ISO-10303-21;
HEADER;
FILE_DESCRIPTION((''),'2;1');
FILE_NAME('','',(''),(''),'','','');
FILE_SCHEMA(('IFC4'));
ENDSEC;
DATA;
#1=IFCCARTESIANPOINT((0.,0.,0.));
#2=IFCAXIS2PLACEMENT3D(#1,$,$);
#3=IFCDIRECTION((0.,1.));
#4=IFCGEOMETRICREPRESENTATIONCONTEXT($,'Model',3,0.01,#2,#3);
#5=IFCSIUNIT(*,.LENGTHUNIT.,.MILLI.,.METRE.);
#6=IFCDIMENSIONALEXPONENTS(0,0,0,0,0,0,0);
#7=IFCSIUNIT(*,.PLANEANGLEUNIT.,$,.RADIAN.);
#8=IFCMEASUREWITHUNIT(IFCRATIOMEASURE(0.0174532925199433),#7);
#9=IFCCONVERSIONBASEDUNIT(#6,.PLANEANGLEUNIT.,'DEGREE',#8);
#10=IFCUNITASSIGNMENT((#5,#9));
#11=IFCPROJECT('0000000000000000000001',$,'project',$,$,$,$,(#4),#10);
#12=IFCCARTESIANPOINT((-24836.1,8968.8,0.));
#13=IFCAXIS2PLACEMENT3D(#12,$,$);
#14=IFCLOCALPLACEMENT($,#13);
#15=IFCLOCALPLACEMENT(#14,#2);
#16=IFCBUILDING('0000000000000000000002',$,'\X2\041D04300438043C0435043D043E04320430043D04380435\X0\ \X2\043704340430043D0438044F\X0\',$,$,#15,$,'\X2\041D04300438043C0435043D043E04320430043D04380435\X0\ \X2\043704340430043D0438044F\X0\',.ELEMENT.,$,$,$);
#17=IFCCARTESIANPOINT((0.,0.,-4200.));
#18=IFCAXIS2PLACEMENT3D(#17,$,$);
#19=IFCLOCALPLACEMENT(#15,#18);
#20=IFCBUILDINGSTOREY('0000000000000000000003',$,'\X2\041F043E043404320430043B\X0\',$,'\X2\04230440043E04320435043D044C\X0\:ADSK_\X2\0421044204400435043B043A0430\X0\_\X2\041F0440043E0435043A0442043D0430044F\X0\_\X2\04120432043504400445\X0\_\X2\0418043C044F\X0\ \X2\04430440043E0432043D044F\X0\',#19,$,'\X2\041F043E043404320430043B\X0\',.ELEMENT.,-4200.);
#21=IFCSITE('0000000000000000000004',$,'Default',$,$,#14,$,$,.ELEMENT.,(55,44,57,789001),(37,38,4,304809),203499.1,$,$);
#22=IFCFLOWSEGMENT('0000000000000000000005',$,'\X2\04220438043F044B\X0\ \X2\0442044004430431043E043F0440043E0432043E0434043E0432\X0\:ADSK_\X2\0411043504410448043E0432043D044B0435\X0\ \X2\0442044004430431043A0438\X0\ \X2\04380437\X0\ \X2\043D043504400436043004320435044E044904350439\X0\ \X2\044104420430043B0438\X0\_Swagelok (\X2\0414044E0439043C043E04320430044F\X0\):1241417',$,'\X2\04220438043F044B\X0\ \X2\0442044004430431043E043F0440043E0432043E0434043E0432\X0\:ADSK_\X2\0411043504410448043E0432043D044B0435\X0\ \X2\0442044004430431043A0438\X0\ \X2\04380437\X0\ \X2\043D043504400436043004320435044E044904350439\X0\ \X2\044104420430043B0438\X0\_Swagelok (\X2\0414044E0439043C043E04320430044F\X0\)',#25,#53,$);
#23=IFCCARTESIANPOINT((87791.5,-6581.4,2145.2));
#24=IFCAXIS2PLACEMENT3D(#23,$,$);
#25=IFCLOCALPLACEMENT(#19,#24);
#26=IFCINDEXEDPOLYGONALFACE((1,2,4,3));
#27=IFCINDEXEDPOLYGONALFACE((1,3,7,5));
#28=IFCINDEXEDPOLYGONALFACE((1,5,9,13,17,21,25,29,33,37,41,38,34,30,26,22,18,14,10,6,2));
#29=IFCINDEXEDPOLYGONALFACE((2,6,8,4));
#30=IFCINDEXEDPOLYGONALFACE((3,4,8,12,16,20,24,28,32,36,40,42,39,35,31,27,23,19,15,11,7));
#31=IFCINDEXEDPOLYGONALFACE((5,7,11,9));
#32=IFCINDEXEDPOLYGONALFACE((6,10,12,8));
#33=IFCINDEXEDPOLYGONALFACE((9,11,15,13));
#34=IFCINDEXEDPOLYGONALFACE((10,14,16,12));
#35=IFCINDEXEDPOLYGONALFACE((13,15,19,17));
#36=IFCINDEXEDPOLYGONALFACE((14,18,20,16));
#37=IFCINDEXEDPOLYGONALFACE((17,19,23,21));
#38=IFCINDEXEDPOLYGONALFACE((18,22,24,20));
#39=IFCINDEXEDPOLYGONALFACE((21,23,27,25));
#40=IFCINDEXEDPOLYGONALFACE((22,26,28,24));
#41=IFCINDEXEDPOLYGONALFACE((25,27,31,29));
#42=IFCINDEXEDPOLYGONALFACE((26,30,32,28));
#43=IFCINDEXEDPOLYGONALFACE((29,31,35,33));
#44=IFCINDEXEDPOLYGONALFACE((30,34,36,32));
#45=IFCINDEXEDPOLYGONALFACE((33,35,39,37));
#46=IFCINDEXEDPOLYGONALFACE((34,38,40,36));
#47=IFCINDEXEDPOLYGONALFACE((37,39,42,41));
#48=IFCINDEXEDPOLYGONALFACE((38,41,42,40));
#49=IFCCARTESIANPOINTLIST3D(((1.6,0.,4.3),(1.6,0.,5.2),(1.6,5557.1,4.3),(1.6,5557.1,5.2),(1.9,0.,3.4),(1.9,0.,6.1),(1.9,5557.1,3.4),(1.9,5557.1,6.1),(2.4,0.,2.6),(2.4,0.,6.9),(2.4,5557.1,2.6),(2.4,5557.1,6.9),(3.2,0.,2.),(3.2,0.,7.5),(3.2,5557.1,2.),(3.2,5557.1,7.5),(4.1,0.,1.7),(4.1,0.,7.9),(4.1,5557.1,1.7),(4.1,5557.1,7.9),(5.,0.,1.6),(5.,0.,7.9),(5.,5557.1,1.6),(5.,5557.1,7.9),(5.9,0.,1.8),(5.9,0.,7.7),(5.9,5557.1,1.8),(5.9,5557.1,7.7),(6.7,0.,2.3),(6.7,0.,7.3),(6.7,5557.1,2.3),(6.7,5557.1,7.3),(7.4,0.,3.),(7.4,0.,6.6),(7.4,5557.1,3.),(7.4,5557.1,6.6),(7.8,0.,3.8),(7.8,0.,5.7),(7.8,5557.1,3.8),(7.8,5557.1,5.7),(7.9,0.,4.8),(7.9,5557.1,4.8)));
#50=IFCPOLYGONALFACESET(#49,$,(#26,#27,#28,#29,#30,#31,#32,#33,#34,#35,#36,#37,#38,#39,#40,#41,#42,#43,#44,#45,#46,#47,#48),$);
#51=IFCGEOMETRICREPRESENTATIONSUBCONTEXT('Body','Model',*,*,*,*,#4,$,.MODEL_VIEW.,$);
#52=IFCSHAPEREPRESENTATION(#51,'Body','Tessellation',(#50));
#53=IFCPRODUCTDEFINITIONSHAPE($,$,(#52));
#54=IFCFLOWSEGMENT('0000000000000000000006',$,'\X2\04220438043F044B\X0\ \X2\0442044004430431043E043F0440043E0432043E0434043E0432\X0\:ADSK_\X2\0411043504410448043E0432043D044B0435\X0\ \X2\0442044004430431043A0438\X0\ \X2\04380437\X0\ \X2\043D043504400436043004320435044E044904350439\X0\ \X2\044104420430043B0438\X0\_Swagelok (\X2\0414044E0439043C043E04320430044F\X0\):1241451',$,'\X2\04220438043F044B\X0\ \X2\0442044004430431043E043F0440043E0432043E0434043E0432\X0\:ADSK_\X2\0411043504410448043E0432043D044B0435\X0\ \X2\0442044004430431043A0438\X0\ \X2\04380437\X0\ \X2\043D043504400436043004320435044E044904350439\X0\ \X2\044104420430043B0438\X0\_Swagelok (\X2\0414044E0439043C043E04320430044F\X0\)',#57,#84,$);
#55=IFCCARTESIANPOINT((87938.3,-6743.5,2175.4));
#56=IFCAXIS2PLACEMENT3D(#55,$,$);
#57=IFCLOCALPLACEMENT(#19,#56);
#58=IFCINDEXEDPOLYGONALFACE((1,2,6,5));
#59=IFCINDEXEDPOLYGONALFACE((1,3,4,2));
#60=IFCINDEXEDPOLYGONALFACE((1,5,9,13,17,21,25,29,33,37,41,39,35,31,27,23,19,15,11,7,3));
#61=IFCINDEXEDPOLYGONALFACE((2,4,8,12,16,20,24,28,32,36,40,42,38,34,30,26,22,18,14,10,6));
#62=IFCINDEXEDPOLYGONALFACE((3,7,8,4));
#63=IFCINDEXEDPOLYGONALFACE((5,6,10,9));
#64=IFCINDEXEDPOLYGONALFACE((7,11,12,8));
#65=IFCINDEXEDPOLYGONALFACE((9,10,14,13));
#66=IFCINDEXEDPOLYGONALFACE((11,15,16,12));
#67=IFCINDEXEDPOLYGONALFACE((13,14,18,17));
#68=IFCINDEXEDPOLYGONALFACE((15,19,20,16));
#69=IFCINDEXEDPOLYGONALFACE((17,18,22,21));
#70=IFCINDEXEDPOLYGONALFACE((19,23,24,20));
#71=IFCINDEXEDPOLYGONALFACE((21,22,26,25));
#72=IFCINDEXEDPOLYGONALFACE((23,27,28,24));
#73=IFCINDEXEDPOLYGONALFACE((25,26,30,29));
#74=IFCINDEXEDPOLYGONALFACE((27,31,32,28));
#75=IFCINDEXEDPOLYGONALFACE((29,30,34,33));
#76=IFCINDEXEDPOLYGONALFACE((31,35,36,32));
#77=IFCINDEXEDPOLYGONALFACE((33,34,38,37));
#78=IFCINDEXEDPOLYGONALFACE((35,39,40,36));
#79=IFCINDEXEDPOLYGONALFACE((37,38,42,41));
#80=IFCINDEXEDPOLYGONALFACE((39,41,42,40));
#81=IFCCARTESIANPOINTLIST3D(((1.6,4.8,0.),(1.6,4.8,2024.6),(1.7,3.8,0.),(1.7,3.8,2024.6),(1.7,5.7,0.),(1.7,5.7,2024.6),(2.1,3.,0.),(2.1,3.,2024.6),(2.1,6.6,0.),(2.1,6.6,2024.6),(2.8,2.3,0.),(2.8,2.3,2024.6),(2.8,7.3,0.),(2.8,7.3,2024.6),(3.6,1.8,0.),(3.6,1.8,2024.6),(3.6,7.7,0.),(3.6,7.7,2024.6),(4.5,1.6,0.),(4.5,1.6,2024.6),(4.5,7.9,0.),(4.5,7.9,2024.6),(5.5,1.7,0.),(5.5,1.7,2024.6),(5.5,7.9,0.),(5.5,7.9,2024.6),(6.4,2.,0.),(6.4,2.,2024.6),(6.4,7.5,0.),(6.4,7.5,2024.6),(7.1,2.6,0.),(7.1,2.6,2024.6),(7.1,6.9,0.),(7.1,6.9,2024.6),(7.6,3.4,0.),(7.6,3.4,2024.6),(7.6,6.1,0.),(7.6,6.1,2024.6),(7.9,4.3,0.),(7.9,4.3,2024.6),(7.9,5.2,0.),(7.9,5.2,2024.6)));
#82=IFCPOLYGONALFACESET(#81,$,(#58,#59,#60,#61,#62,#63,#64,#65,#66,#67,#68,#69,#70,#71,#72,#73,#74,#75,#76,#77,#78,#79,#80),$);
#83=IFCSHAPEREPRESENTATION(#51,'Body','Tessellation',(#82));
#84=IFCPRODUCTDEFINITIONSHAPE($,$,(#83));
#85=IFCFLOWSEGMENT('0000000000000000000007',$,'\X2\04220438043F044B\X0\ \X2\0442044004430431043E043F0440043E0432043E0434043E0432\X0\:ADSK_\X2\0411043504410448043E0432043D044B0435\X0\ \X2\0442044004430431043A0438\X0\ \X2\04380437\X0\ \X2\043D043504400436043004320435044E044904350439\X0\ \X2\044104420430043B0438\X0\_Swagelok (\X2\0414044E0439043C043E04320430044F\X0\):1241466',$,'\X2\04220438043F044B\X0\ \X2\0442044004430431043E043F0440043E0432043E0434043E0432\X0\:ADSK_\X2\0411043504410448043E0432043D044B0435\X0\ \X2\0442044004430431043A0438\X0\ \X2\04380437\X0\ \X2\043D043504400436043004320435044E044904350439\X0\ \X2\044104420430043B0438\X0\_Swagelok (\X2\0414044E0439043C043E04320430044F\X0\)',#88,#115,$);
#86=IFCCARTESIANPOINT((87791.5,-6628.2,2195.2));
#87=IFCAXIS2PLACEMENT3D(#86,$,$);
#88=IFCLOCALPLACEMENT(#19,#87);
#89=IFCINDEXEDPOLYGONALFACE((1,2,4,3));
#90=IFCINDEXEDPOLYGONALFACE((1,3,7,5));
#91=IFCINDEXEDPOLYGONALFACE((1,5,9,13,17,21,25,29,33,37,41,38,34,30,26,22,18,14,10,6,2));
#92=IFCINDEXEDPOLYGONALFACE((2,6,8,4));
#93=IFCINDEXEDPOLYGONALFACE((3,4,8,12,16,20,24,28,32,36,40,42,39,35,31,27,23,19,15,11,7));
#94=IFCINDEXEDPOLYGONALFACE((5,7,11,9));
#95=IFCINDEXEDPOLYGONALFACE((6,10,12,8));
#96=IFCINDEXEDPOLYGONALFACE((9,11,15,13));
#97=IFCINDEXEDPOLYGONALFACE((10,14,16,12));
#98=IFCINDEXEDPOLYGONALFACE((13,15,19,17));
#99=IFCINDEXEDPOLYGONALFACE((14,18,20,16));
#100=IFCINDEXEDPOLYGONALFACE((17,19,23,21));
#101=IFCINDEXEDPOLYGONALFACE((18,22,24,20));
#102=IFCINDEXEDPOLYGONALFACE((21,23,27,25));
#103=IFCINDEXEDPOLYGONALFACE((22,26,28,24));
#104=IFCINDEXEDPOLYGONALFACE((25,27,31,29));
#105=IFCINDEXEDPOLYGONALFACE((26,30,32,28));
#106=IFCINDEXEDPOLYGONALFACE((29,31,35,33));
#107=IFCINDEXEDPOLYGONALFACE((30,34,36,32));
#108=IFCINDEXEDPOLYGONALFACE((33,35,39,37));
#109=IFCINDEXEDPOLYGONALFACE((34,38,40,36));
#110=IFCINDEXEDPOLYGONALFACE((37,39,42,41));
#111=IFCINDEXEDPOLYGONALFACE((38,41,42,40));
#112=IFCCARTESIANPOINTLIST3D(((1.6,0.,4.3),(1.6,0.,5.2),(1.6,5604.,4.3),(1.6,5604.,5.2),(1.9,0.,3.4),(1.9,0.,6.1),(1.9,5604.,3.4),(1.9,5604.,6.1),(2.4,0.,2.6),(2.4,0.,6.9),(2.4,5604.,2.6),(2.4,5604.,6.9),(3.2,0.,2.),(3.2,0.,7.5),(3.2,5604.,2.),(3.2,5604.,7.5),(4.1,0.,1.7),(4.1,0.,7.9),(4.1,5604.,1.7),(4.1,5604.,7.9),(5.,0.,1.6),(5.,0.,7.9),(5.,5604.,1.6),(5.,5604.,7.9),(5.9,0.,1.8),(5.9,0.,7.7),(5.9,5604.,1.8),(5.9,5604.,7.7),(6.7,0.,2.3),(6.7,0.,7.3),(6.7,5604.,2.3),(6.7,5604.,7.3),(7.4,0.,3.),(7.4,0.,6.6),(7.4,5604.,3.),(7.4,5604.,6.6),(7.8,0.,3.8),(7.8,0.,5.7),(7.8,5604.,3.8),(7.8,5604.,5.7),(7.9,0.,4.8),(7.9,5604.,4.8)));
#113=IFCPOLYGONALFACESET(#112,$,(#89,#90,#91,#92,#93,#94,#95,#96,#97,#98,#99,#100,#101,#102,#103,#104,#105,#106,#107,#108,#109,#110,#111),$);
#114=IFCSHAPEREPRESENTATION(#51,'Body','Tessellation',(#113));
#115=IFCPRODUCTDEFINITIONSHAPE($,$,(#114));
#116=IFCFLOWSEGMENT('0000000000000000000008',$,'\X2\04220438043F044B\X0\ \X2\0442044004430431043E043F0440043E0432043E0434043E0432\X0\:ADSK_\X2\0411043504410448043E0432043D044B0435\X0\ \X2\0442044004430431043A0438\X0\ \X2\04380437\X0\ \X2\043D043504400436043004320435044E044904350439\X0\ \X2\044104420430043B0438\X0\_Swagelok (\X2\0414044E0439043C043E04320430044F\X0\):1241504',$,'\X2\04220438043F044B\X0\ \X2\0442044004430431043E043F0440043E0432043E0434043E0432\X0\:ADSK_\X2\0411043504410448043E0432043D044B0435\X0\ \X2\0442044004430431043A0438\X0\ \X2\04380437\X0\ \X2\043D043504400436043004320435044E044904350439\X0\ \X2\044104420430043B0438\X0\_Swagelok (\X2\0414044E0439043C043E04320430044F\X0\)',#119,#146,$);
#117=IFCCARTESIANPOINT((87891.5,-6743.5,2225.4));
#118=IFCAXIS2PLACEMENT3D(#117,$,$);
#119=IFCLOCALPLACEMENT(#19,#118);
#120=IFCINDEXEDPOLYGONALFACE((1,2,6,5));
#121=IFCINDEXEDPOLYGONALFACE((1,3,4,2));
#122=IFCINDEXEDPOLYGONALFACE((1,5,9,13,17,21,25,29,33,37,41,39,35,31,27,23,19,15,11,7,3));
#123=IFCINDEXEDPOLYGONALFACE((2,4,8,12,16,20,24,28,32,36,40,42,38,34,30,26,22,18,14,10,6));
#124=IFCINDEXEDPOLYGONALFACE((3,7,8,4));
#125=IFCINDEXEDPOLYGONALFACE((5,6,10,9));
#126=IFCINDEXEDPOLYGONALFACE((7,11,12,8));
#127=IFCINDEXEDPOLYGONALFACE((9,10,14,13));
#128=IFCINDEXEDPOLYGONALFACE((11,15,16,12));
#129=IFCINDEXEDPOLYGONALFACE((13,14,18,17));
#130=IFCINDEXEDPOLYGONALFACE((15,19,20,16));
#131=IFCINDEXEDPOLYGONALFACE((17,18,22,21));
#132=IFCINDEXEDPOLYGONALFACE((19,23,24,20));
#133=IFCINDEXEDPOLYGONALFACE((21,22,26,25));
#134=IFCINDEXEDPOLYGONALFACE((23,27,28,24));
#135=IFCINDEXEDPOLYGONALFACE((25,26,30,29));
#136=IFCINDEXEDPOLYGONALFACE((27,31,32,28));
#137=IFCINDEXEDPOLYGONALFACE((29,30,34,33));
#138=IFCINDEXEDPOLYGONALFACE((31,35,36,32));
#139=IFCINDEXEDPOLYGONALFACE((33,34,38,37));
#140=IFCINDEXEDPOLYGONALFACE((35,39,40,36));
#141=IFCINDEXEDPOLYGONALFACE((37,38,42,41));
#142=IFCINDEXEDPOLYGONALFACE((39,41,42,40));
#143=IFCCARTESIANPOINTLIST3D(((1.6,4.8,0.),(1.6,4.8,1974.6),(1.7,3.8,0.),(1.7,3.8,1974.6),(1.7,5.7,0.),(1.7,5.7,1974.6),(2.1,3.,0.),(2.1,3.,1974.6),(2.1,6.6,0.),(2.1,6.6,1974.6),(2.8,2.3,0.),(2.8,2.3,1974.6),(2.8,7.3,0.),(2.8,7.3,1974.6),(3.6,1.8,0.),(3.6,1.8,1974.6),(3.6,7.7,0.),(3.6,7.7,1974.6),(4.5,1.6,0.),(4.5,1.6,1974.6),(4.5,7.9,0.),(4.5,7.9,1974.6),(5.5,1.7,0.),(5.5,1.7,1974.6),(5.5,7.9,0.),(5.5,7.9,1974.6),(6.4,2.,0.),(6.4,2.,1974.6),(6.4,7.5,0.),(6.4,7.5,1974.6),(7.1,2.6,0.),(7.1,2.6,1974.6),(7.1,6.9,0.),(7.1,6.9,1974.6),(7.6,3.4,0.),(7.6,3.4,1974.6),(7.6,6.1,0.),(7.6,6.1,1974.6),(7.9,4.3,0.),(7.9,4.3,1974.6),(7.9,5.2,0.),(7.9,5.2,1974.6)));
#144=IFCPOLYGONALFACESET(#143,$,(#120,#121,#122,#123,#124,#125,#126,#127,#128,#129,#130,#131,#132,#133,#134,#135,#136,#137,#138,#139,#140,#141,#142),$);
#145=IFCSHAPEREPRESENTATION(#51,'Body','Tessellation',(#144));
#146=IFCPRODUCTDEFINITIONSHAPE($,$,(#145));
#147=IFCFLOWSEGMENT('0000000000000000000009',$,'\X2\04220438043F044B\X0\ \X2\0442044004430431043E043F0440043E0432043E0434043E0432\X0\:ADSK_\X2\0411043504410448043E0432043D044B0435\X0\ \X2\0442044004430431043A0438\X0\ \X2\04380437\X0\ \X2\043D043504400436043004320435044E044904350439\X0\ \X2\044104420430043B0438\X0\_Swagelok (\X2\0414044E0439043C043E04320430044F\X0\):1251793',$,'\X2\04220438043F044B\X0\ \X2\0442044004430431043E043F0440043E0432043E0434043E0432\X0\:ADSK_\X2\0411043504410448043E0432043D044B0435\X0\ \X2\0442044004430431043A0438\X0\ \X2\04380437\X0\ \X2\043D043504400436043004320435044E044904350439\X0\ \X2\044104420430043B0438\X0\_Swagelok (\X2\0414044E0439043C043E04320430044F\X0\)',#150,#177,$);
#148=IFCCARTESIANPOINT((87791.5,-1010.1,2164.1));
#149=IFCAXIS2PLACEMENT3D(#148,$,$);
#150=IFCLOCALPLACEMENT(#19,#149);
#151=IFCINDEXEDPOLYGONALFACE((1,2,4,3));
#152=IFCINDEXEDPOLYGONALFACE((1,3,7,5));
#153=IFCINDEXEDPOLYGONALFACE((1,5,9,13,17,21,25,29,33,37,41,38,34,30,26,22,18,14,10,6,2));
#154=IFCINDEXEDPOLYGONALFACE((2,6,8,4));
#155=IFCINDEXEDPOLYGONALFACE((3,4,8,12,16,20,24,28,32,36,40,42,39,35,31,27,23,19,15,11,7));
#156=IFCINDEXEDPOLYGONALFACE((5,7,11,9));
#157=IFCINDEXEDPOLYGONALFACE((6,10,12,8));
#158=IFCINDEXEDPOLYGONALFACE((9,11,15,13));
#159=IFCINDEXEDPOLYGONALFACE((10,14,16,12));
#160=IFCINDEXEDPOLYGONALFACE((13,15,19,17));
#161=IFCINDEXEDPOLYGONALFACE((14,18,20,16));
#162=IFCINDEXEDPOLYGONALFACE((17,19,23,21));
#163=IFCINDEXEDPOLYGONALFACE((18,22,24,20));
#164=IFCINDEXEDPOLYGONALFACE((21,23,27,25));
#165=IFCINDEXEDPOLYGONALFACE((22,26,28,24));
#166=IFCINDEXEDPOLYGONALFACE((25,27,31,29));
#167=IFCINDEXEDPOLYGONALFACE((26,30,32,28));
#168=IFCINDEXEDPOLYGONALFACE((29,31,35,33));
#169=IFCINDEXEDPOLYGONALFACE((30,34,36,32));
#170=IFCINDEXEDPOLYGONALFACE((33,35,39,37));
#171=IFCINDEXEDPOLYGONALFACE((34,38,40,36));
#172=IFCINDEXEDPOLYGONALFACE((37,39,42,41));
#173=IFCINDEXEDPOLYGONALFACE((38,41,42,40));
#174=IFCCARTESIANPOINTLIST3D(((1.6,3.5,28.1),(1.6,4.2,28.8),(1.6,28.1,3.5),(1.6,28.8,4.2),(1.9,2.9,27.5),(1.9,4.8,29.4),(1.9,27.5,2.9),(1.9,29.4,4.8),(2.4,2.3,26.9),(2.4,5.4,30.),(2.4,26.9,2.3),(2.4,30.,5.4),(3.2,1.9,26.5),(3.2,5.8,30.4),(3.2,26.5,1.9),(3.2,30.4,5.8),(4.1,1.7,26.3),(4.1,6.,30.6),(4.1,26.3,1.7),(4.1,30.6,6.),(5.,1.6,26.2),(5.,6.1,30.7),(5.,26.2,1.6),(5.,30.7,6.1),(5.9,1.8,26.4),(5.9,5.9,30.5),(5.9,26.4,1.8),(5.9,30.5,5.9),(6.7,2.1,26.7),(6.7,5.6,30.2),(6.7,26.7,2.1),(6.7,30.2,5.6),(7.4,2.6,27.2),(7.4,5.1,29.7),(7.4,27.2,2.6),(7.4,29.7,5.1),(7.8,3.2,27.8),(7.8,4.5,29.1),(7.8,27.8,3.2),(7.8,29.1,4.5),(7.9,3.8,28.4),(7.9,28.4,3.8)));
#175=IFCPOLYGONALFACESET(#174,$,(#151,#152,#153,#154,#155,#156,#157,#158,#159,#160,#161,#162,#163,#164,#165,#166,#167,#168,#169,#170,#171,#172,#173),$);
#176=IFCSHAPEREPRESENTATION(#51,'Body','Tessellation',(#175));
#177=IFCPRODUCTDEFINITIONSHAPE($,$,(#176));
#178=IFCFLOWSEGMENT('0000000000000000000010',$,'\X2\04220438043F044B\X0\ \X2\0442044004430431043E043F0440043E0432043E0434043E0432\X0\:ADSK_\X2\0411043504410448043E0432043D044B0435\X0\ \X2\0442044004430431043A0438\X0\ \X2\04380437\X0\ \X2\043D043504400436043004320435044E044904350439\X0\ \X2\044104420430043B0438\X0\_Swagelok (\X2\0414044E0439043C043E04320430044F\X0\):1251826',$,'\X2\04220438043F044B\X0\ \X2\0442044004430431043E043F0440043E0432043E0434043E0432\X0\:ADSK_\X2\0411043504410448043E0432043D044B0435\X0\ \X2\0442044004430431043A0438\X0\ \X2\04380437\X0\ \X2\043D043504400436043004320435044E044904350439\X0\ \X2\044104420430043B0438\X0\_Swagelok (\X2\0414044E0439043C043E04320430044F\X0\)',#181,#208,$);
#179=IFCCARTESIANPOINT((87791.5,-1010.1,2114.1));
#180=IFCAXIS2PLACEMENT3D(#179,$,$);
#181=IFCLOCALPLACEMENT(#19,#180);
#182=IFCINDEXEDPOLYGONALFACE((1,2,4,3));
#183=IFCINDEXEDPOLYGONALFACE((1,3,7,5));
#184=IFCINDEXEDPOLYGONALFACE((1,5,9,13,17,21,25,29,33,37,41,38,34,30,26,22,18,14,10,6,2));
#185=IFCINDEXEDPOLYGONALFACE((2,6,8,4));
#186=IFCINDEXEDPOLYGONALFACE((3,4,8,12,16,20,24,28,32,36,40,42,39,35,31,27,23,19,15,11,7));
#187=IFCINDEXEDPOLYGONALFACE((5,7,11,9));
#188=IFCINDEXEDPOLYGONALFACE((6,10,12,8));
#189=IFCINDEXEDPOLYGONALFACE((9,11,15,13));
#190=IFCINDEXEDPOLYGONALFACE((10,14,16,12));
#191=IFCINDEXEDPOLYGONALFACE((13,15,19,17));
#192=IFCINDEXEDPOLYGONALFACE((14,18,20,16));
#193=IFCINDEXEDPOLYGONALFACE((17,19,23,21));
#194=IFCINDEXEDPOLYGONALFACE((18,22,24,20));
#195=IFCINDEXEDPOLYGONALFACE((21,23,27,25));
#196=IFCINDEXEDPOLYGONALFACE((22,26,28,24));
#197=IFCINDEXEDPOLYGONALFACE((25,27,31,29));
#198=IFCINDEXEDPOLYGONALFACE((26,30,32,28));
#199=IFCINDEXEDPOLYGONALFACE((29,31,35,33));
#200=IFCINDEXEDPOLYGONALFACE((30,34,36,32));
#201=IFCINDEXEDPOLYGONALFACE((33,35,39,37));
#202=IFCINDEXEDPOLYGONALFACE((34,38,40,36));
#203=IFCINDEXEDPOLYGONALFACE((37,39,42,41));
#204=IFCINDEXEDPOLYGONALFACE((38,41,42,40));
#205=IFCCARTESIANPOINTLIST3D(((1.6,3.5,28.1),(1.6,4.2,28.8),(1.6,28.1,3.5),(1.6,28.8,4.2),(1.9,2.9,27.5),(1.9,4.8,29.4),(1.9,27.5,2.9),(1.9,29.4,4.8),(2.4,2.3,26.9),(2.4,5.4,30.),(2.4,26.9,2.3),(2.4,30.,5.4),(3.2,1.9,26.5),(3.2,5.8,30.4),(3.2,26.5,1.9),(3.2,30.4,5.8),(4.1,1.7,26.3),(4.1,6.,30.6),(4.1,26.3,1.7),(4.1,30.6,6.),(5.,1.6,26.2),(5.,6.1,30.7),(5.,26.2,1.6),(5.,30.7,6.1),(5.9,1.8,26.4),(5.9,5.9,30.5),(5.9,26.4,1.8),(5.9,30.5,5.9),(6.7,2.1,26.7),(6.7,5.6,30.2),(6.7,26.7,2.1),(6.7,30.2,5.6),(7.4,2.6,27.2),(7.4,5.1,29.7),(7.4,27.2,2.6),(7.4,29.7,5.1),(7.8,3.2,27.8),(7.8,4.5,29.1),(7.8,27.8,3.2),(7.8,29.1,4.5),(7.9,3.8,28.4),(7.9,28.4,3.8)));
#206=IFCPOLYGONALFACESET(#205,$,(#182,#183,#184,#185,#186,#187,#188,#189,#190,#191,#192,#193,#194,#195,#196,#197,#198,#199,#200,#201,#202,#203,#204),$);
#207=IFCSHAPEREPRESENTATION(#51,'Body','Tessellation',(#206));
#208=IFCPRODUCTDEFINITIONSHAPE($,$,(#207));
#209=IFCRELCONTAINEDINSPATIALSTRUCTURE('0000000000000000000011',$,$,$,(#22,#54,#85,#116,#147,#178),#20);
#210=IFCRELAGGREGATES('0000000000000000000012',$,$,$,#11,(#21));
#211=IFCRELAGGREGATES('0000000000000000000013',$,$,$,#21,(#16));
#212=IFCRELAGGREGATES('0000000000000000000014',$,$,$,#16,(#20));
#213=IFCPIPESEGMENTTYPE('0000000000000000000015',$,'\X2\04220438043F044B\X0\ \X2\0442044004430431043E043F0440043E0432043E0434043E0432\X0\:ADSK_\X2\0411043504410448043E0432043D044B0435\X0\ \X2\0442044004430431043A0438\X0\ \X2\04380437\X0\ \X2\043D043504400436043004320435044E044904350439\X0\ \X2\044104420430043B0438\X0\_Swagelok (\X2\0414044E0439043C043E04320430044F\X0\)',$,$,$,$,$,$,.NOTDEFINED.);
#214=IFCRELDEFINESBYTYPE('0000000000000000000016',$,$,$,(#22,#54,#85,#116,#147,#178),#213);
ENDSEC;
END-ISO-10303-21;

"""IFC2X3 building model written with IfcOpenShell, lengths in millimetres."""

from ifc_helpers import new_model, entity, si_unit, converted_unit, direction, frame, origin, origin_2d_with_axis, place, context, subcontext, project, spatial, circle, extrude, type_object, element, save


model = new_model("IFC2X3")

# Units and contexts
model_context = context("Model", 3, precision=0.01, world=origin(), true_north=direction((0.0, 1.0)))
body_context = subcontext(model_context, "Body", "Model", "MODEL_VIEW")
ifc_project = project(units=[si_unit("LENGTHUNIT", "METRE", prefix="MILLI"), converted_unit("PLANEANGLEUNIT", "DEGREE", entity("IfcRatioMeasure", 0.0174532925199433), si_unit("PLANEANGLEUNIT", "RADIAN"), dimensions=[0, 0, 0, 0, 0, 0, 0])], contexts=[model_context])

# Site, building, storey
site_placement = place(None, frame((-24836.1, 8968.8, 0.0)))
site = spatial("IfcSite", under=ifc_project, at=site_placement, Name="Default", CompositionType="ELEMENT", RefLatitude=(55, 44, 57, 789001), RefLongitude=(37, 38, 4, 304809), RefElevation=203499.1)
building_placement = place(site_placement, origin())
building = spatial("IfcBuilding", under=site, at=building_placement, Name="Наименование здания", LongName="Наименование здания", CompositionType="ELEMENT")
storey_placement = place(building_placement, frame((0.0, 0.0, -4200.0)))
storey = spatial("IfcBuildingStorey", under=building, at=storey_placement, Name="Подвал", ObjectType="Уровень:ADSK_Стрелка_Проектная_Вверх_Имя уровня", LongName="Подвал", CompositionType="ELEMENT", Elevation=-4200.0)

# Flow segments
pipe_segment_type_1 = type_object("IfcPipeSegmentType", Name="Типы трубопроводов:ADSK_Бесшовные трубки из нержавеющей стали_Swagelok (Дюймовая)", PredefinedType="NOTDEFINED")
flow_segment_1_placement = place(storey_placement, frame((87791.5, -6581.4, 2145.2)))
element("IfcFlowSegment", 1, at=flow_segment_1_placement, inside=storey, type_object=pipe_segment_type_1, Name="Типы трубопроводов:ADSK_Бесшовные трубки из нержавеющей стали_Swagelok (Дюймовая):1241417", ObjectType="Типы трубопроводов:ADSK_Бесшовные трубки из нержавеющей стали_Swagelok (Дюймовая)", context=body_context, shape_type="SweptSolid", body=[
    extrude(circle(Radius=3.2, at=origin_2d_with_axis()), frame((4.8, 0.0, 4.8), z_axis=(0.0, 1.0, 0.0), x_axis=(1.0, 0.0, 0.0)), (0.0, 0.0, 1.0), 5557.1),
])
flow_segment_2_placement = place(storey_placement, frame((87938.3, -6743.5, 2175.4)))
element("IfcFlowSegment", 2, at=flow_segment_2_placement, inside=storey, type_object=pipe_segment_type_1, Name="Типы трубопроводов:ADSK_Бесшовные трубки из нержавеющей стали_Swagelok (Дюймовая):1241451", ObjectType="Типы трубопроводов:ADSK_Бесшовные трубки из нержавеющей стали_Swagelok (Дюймовая)", context=body_context, shape_type="SweptSolid", body=[
    extrude(circle(Radius=3.2, at=origin_2d_with_axis()), frame((4.8, 4.8, 0.0), z_axis=(0.0, 0.0, 1.0), x_axis=(-1.0, 0.0, 0.0)), (0.0, 0.0, 1.0), 2024.6),
])
flow_segment_3_placement = place(storey_placement, frame((87791.5, -6628.2, 2195.2)))
element("IfcFlowSegment", 3, at=flow_segment_3_placement, inside=storey, type_object=pipe_segment_type_1, Name="Типы трубопроводов:ADSK_Бесшовные трубки из нержавеющей стали_Swagelok (Дюймовая):1241466", ObjectType="Типы трубопроводов:ADSK_Бесшовные трубки из нержавеющей стали_Swagelok (Дюймовая)", context=body_context, shape_type="SweptSolid", body=[
    extrude(circle(Radius=3.2, at=origin_2d_with_axis()), frame((4.8, 0.0, 4.8), z_axis=(0.0, 1.0, 0.0), x_axis=(1.0, 0.0, 0.0)), (0.0, 0.0, 1.0), 5604.0),
])
flow_segment_4_placement = place(storey_placement, frame((87891.5, -6743.5, 2225.4)))
element("IfcFlowSegment", 4, at=flow_segment_4_placement, inside=storey, type_object=pipe_segment_type_1, Name="Типы трубопроводов:ADSK_Бесшовные трубки из нержавеющей стали_Swagelok (Дюймовая):1241504", ObjectType="Типы трубопроводов:ADSK_Бесшовные трубки из нержавеющей стали_Swagelok (Дюймовая)", context=body_context, shape_type="SweptSolid", body=[
    extrude(circle(Radius=3.2, at=origin_2d_with_axis()), frame((4.8, 4.8, 0.0), z_axis=(0.0, 0.0, 1.0), x_axis=(-1.0, 0.0, 0.0)), (0.0, 0.0, 1.0), 1974.6),
])
flow_segment_5_placement = place(storey_placement, frame((87791.5, -1010.1, 2164.1)))
element("IfcFlowSegment", 5, at=flow_segment_5_placement, inside=storey, type_object=pipe_segment_type_1, Name="Типы трубопроводов:ADSK_Бесшовные трубки из нержавеющей стали_Swagelok (Дюймовая):1251793", ObjectType="Типы трубопроводов:ADSK_Бесшовные трубки из нержавеющей стали_Swagelok (Дюймовая)", context=body_context, shape_type="SweptSolid", body=[
    extrude(circle(Radius=3.2, at=origin_2d_with_axis()), frame((4.8, 3.8, 28.4), z_axis=(0.0, 0.707107, -0.707107), x_axis=(1.0, 0.0, 0.0)), (0.0, 0.0, 1.0), 34.8),
])
flow_segment_6_placement = place(storey_placement, frame((87791.5, -1010.1, 2114.1)))
element("IfcFlowSegment", 6, at=flow_segment_6_placement, inside=storey, type_object=pipe_segment_type_1, Name="Типы трубопроводов:ADSK_Бесшовные трубки из нержавеющей стали_Swagelok (Дюймовая):1251826", ObjectType="Типы трубопроводов:ADSK_Бесшовные трубки из нержавеющей стали_Swagelok (Дюймовая)", context=body_context, shape_type="SweptSolid", body=[
    extrude(circle(Radius=3.2, at=origin_2d_with_axis()), frame((4.8, 3.8, 28.4), z_axis=(0.0, 0.707107, -0.707107), x_axis=(1.0, 0.0, 0.0)), (0.0, 0.0, 1.0), 34.8),
])

save(model, "model.ifc")
